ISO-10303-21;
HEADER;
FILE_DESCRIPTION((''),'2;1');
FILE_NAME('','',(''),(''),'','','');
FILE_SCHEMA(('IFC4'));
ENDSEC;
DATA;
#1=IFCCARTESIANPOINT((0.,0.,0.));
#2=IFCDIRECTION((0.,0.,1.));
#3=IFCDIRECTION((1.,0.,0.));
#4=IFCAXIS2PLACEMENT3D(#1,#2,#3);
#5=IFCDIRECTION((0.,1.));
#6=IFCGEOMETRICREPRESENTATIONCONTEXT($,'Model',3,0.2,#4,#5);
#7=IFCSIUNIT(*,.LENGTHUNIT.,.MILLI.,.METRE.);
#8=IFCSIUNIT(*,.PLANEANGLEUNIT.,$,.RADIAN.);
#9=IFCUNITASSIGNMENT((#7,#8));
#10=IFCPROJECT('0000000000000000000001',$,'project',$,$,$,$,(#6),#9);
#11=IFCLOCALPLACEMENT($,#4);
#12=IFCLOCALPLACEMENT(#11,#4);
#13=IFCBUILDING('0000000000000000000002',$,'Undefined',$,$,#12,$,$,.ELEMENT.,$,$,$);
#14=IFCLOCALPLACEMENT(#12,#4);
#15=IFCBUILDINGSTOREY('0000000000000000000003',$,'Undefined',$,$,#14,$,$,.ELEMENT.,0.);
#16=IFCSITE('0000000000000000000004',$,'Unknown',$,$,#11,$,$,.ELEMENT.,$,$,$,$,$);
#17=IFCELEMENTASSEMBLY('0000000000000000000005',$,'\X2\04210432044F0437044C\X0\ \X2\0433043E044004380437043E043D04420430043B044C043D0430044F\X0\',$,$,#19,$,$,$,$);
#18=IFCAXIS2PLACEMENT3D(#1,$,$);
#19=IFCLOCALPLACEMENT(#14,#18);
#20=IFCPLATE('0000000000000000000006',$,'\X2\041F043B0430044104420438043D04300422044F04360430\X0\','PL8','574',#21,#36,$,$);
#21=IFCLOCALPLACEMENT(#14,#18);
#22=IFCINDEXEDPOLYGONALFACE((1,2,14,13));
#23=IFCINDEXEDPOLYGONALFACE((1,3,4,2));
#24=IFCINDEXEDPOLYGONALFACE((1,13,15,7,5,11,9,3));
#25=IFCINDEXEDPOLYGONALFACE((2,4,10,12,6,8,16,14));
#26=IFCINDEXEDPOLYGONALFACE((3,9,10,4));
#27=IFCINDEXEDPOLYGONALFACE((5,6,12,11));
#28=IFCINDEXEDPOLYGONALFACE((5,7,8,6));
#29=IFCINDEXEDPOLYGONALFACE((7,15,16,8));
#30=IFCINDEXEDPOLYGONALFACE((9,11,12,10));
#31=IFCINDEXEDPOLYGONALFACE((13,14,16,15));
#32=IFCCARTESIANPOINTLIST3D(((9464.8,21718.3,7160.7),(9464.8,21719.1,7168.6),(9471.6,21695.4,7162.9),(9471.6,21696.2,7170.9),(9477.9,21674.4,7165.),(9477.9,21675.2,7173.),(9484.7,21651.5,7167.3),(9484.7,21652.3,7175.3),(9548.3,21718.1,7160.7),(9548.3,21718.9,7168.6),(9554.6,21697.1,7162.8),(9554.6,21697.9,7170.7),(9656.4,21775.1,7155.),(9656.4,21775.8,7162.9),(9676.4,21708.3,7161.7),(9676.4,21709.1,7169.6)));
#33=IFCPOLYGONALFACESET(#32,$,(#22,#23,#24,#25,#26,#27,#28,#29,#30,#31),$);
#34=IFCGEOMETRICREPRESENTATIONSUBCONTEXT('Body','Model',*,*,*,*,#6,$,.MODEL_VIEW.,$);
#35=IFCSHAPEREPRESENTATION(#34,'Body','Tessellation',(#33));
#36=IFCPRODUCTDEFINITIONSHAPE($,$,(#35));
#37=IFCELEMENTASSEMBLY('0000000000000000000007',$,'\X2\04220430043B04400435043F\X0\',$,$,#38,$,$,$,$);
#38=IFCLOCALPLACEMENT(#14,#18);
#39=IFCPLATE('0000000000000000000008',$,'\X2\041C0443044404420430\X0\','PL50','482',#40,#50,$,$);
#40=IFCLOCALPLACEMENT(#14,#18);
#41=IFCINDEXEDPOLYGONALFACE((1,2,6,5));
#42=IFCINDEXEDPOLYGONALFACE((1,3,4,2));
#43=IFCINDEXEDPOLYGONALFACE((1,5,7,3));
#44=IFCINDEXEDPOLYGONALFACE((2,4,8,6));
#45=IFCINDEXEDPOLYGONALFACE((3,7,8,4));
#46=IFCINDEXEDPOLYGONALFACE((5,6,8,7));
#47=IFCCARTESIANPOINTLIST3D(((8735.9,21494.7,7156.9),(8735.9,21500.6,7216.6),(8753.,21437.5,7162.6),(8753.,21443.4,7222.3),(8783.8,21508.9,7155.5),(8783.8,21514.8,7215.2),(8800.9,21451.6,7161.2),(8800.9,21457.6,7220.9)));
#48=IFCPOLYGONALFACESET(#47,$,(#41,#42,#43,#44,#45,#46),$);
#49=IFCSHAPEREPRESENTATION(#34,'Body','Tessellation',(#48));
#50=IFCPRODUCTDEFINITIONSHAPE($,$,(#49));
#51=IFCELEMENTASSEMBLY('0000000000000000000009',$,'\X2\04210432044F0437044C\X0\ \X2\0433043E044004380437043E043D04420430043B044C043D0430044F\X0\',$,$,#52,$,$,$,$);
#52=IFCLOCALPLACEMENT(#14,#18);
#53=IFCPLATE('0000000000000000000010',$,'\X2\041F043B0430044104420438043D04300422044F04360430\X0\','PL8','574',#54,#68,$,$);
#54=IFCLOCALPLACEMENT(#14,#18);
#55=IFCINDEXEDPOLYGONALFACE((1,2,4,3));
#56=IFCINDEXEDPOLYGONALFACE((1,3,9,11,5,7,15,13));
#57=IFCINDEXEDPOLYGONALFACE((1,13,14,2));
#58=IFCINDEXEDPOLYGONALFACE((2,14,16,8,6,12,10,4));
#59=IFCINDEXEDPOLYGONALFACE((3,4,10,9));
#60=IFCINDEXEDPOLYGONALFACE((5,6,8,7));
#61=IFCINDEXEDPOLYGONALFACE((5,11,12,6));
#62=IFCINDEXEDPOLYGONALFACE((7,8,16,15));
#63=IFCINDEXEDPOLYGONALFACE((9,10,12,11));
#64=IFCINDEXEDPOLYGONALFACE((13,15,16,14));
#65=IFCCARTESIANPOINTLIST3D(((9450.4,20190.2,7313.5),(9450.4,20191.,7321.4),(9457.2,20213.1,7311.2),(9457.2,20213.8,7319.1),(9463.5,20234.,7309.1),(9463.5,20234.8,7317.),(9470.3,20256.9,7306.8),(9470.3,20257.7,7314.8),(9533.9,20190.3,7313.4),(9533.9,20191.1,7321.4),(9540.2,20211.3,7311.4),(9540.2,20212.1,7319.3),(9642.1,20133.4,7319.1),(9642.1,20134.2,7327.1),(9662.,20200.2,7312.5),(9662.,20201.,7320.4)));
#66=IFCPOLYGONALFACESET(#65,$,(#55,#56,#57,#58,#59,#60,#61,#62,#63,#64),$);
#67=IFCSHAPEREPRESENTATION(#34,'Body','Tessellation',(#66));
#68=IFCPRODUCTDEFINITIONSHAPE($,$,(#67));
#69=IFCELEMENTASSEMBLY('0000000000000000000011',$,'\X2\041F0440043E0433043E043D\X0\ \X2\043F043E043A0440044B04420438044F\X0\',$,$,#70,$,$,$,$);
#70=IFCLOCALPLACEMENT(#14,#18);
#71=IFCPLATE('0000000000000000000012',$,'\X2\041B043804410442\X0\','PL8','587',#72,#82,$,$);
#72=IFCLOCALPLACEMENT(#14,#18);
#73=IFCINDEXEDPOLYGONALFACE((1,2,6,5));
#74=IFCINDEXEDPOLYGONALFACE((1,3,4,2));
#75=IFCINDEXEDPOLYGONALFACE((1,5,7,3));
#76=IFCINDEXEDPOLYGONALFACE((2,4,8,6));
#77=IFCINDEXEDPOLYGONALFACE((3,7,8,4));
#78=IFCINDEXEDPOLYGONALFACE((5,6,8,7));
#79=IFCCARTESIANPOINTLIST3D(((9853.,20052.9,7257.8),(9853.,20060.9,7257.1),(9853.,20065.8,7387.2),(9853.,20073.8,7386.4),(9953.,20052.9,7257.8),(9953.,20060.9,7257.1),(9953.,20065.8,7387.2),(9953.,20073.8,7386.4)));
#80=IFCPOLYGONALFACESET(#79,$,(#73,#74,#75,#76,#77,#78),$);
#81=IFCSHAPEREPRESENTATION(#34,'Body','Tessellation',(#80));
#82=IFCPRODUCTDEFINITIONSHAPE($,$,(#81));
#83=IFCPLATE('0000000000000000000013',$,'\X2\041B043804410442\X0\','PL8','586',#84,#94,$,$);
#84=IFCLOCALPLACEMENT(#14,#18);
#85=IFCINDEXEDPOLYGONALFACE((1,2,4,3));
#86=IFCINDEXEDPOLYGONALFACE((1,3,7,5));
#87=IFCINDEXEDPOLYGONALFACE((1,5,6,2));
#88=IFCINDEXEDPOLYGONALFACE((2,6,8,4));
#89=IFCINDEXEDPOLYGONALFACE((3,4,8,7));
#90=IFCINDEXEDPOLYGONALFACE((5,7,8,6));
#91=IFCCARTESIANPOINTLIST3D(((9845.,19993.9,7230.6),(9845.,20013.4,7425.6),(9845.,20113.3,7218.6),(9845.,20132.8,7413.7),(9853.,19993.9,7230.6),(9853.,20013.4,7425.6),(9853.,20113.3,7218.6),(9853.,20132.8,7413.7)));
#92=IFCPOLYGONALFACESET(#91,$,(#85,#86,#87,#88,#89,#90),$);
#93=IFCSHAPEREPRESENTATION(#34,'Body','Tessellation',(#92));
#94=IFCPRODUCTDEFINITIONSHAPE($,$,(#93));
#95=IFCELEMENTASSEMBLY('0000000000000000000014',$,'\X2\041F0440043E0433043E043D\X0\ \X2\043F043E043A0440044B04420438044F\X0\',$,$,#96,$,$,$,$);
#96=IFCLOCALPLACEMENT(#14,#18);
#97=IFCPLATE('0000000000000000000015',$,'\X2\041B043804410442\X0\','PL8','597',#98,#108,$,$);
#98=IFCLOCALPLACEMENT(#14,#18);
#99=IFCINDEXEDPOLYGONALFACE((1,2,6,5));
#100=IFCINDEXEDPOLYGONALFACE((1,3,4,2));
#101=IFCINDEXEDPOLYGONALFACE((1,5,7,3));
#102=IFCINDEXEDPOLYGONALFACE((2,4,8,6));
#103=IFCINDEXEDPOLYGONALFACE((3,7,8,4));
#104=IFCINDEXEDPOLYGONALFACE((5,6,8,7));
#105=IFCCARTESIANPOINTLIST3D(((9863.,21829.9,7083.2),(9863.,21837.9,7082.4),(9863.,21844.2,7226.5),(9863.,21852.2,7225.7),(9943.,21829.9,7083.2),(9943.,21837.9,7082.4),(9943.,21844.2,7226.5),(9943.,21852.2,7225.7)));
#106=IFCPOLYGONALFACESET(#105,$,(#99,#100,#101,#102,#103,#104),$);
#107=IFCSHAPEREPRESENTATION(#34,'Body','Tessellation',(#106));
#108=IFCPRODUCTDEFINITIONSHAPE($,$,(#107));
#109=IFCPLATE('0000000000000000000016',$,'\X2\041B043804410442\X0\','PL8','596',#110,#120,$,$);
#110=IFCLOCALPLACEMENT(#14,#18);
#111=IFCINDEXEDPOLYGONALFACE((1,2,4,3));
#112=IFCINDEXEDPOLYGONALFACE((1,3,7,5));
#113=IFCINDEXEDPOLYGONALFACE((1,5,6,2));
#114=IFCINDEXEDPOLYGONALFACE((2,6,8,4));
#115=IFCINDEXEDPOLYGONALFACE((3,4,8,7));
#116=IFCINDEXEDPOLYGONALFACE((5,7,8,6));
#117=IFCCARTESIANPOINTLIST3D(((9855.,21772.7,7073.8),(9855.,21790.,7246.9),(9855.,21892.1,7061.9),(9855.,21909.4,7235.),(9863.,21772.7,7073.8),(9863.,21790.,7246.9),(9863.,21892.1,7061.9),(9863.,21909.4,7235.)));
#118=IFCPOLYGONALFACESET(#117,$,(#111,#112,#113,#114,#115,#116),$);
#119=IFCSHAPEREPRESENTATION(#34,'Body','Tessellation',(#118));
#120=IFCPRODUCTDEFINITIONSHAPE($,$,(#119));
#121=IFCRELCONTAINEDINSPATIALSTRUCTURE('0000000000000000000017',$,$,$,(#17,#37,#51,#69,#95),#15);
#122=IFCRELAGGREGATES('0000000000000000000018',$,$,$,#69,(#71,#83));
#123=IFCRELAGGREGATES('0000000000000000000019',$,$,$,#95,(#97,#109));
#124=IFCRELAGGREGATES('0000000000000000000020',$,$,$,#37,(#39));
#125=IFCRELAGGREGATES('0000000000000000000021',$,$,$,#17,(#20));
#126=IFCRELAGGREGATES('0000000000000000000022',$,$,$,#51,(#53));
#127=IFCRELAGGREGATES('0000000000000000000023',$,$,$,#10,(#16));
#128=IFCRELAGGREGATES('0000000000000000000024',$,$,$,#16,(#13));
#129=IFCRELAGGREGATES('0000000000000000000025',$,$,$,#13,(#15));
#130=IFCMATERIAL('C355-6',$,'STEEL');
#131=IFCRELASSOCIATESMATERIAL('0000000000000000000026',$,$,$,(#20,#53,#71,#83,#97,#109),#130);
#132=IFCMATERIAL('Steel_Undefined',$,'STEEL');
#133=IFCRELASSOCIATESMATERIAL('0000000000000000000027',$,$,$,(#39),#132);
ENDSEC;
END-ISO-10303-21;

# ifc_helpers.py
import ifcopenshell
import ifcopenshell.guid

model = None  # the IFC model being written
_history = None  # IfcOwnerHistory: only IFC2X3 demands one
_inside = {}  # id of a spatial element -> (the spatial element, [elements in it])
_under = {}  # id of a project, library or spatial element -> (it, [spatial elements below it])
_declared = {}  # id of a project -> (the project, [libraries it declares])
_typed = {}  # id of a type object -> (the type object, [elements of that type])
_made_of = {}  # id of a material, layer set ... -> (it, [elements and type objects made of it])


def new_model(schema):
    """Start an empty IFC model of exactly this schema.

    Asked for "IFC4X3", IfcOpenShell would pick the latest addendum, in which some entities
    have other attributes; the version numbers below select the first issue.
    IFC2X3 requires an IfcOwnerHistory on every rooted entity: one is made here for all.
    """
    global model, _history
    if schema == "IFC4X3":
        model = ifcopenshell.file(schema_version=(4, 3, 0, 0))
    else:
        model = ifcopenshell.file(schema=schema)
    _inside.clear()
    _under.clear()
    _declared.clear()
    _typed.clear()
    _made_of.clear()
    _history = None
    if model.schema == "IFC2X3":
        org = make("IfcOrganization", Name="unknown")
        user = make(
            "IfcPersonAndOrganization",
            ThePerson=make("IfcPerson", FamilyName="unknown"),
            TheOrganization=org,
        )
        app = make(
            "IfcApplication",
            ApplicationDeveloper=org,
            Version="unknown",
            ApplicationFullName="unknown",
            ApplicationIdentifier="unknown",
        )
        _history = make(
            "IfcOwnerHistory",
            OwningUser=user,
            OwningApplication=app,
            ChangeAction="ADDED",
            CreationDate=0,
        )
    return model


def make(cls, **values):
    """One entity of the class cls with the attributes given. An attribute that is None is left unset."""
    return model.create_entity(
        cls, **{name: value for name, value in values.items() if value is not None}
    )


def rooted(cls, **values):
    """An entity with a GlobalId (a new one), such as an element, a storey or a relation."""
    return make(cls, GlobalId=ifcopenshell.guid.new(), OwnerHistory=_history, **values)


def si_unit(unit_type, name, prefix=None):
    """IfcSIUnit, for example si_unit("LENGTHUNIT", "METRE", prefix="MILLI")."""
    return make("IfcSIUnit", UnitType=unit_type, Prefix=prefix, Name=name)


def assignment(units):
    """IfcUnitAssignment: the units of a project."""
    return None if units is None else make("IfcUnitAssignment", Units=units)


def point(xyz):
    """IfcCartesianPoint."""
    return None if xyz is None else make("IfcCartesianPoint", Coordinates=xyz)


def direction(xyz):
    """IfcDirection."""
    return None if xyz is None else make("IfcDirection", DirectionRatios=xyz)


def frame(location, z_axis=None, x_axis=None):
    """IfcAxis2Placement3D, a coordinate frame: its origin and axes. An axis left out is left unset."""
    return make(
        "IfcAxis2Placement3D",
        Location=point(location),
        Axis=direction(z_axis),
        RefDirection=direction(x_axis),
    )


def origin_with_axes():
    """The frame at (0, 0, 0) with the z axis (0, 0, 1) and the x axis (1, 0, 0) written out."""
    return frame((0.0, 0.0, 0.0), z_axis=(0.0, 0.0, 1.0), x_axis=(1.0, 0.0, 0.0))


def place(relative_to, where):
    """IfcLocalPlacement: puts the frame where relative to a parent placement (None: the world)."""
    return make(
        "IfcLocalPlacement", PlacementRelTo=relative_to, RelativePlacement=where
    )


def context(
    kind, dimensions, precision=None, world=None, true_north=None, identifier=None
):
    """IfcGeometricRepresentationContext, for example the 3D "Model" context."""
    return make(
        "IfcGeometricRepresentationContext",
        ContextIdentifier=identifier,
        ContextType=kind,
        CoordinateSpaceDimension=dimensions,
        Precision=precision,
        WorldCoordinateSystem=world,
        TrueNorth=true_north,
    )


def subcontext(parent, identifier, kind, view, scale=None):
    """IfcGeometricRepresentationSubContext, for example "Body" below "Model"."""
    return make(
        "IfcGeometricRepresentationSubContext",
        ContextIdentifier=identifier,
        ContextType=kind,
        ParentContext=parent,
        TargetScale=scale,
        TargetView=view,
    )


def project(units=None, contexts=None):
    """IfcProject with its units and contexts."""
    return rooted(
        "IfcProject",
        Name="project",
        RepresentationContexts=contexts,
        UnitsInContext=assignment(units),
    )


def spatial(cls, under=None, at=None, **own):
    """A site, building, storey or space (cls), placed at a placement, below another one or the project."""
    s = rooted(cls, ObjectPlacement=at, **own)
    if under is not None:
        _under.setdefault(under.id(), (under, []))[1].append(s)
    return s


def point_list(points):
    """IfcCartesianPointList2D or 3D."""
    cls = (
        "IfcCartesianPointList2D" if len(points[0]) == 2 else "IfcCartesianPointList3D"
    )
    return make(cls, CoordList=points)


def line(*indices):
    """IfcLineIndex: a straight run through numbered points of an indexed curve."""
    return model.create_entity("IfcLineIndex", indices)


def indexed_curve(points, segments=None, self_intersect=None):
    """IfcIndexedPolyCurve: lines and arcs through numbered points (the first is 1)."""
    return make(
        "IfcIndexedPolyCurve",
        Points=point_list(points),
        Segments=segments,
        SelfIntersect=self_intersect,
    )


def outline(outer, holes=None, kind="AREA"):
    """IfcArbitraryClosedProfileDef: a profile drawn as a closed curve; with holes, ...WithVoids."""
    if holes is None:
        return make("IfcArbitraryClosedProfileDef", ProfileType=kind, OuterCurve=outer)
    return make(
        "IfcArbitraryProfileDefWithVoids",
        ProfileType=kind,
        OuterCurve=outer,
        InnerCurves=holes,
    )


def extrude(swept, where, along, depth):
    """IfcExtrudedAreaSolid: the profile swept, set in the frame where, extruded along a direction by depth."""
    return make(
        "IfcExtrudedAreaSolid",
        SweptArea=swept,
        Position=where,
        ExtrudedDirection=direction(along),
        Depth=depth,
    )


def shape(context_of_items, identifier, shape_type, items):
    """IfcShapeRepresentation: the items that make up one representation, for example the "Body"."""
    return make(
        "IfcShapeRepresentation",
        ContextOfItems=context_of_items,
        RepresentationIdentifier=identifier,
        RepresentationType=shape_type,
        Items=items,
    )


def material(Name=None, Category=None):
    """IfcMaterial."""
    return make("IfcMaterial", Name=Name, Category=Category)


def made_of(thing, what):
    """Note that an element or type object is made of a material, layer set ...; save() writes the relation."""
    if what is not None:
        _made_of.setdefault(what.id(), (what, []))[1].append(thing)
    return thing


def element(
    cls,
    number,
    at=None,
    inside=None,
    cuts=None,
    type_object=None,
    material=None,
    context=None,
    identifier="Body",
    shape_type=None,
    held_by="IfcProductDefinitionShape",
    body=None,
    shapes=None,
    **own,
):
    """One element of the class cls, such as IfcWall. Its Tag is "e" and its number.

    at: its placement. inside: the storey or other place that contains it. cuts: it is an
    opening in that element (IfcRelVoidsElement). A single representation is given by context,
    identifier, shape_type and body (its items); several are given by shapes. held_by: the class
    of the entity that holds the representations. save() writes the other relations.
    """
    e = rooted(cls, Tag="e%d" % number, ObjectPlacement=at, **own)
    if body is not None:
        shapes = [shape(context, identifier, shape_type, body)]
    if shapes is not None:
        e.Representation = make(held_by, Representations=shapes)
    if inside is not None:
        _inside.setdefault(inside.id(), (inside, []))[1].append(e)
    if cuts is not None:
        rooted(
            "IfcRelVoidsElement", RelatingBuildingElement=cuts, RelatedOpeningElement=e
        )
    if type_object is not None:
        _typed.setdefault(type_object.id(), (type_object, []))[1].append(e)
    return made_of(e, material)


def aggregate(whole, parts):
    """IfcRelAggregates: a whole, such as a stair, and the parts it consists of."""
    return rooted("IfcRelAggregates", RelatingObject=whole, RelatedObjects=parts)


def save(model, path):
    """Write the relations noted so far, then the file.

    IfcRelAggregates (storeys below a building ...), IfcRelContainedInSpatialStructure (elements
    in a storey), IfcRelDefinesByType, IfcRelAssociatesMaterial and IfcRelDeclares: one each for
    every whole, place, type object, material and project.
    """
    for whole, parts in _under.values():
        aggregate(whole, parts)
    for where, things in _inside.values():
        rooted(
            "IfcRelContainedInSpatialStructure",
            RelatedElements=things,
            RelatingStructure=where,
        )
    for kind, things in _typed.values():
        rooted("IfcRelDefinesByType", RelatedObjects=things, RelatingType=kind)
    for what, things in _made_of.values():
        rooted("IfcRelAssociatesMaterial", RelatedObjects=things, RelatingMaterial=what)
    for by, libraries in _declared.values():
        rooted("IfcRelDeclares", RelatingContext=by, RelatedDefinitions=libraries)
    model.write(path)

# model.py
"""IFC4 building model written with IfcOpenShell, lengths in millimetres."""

from ifc_helpers import new_model, si_unit, direction, frame, origin_with_axes, place, context, subcontext, project, spatial, line, indexed_curve, outline, extrude, material, element, aggregate, save


model = new_model("IFC4")

# Units and contexts
model_context = context("Model", 3, precision=0.2, world=origin_with_axes(), true_north=direction((0.0, 1.0)))
body_context = subcontext(model_context, "Body", "Model", "MODEL_VIEW")
ifc_project = project(units=[si_unit("LENGTHUNIT", "METRE", prefix="MILLI"), si_unit("PLANEANGLEUNIT", "RADIAN")], contexts=[model_context])

# Site, building, storey
site_placement = place(None, origin_with_axes())
site = spatial("IfcSite", under=ifc_project, at=site_placement, Name="Unknown", CompositionType="ELEMENT")
building_placement = place(site_placement, origin_with_axes())
building = spatial("IfcBuilding", under=site, at=building_placement, Name="Undefined", CompositionType="ELEMENT")
storey_placement = place(building_placement, origin_with_axes())
storey = spatial("IfcBuildingStorey", under=building, at=storey_placement, Name="Undefined", CompositionType="ELEMENT", Elevation=0.0)

# Shared definitions
ifc_material_1 = material(Name="Steel_Undefined", Category="STEEL")

# Shared definitions
ifc_material_2 = material(Name="C355-6", Category="STEEL")

# Element assembly, plate, voiding feature
assembly_1_placement = place(storey_placement, frame((8658.2, 21443.5, 7192.2), z_axis=(0.285231, -0.953702, 0.09537), x_axis=(0.958459, 0.283816, -0.028382)))
assembly_1 = element("IfcElementAssembly", 1, at=assembly_1_placement, inside=storey, Name="Связь горизонтальная")
plate_1_placement = place(assembly_1_placement, frame((1052.0, 0.0, 35.0), z_axis=(0.0, 1.0, 0.0), x_axis=(0.0, 0.0, -1.0)))
plate_1 = element("IfcPlate", 2, at=plate_1_placement, material=ifc_material_2, Name="ПластинаТяжа", Description="PL8", ObjectType="574", context=body_context, shape_type="SolidModel", body=[
    extrude(outline(indexed_curve([(0.0, 0.0), (70.0, 0.0), (70.0, 200.0), (0.0, 200.0)], segments=[line(1, 2, 3, 4, 1)])), frame((0.0, 0.0, 4.0), z_axis=(0.0, 0.0, 1.0), x_axis=(1.0, 0.0, 0.0)), (0.0, 0.0, -1.0), 8.0),
])
voiding_feature_1_placement = place(plate_1_placement, frame((24.0, 120.0, 0.0), z_axis=(0.0, 0.0, 1.0), x_axis=(1.0, 0.0, 0.0)))
element("IfcVoidingFeature", 3, at=voiding_feature_1_placement, cuts=plate_1, Name="PLATE", ObjectType="(?)", PredefinedType="HOLE", context=body_context, shape_type="SolidModel", body=[
    extrude(outline(indexed_curve([(0.0, 0.0), (22.0, 0.0), (22.0, 85.0), (0.0, 85.0)], segments=[line(1, 2, 3, 4, 1)])), frame((0.0, 0.0, 6.5), z_axis=(0.0, 0.0, 1.0), x_axis=(1.0, 0.0, 0.0)), (0.0, 0.0, -1.0), 13.0),
])

# Element assembly, plate
assembly_2_placement = place(storey_placement, frame((8776.9, 21450.5, 7221.6), z_axis=(-0.958459, -0.283816, 0.028382), x_axis=(-0.285231, 0.953702, -0.09537)))
assembly_2 = element("IfcElementAssembly", 4, at=assembly_2_placement, inside=storey, Name="Талреп")
plate_2_placement = place(assembly_2_placement, origin_with_axes())
plate_2 = element("IfcPlate", 5, at=plate_2_placement, material=ifc_material_1, Name="Муфта", Description="PL50", ObjectType="482", context=body_context, shape_type="SolidModel", body=[
    extrude(outline(indexed_curve([(0.0, 0.0), (60.0, 0.0), (60.0, 60.0), (0.0, 60.0)], segments=[line(1, 2, 3, 4, 1)])), frame((0.0, 0.0, 25.0), z_axis=(0.0, 0.0, 1.0), x_axis=(1.0, 0.0, 0.0)), (0.0, 0.0, -1.0), 50.0),
])

# Element assembly, plate, voiding feature
assembly_3_placement = place(storey_placement, frame((8658.2, 20461.5, 7290.4), z_axis=(-0.285231, -0.953702, 0.09537), x_axis=(0.958459, -0.283816, 0.028382)))
assembly_3 = element("IfcElementAssembly", 6, at=assembly_3_placement, inside=storey, Name="Связь горизонтальная")
plate_3_placement = place(assembly_3_placement, frame((1037.0, 0.0, 35.0), z_axis=(0.0, 1.0, 0.0), x_axis=(0.0, 0.0, -1.0)))
plate_3 = element("IfcPlate", 7, at=plate_3_placement, material=ifc_material_2, Name="ПластинаТяжа", Description="PL8", ObjectType="574", context=body_context, shape_type="SolidModel", body=[
    extrude(outline(indexed_curve([(0.0, 0.0), (70.0, 0.0), (70.0, 200.0), (0.0, 200.0)], segments=[line(1, 2, 3, 4, 1)])), frame((0.0, 0.0, 4.0), z_axis=(0.0, 0.0, 1.0), x_axis=(1.0, 0.0, 0.0)), (0.0, 0.0, -1.0), 8.0),
])
voiding_feature_2_placement = place(plate_3_placement, frame((24.0, 120.0, 0.0), z_axis=(0.0, 0.0, 1.0), x_axis=(1.0, 0.0, 0.0)))
element("IfcVoidingFeature", 8, at=voiding_feature_2_placement, cuts=plate_3, Name="PLATE", ObjectType="(?)", PredefinedType="HOLE", context=body_context, shape_type="SolidModel", body=[
    extrude(outline(indexed_curve([(0.0, 0.0), (22.0, 0.0), (22.0, 85.0), (0.0, 85.0)], segments=[line(1, 2, 3, 4, 1)])), frame((0.0, 0.0, 6.5), z_axis=(0.0, 0.0, 1.0), x_axis=(1.0, 0.0, 0.0)), (0.0, 0.0, -1.0), 13.0),
])

# Element assemblies, plates
assembly_4_placement = place(storey_placement, frame((10000.0, 20063.3, 7322.1), z_axis=(0.0, -0.995037, 0.099504), x_axis=(-1.0, 0.0, 0.0)))
assembly_4 = element("IfcElementAssembly", 9, at=assembly_4_placement, inside=storey, Name="Прогон покрытия")
plate_4_placement = place(assembly_4_placement, frame((47.0, -65.0, 0.0), z_axis=(0.0, 0.0, 1.0), x_axis=(1.0, 0.0, 0.0)))
plate_4 = element("IfcPlate", 10, at=plate_4_placement, material=ifc_material_2, Name="Лист", Description="PL8", ObjectType="587", context=body_context, shape_type="SolidModel", body=[
    extrude(outline(indexed_curve([(0.0, 0.0), (100.0, 0.0), (100.0, 130.0), (0.0, 130.0)], segments=[line(1, 2, 3, 4, 1)])), frame((0.0, 0.0, 4.0), z_axis=(0.0, 0.0, 1.0), x_axis=(1.0, 0.0, 0.0)), (0.0, 0.0, -1.0), 8.0),
])
plate_5_placement = place(assembly_4_placement, frame((151.0, -98.0, -60.0), z_axis=(-1.0, 0.0, 0.0), x_axis=(0.0, 0.0, 1.0)))
plate_5 = element("IfcPlate", 11, at=plate_5_placement, material=ifc_material_2, Name="Лист", Description="PL8", ObjectType="586", context=body_context, shape_type="SolidModel", body=[
    extrude(outline(indexed_curve([(0.0, 0.0), (120.0, 0.0), (120.0, 196.0), (0.0, 196.0)], segments=[line(1, 2, 3, 4, 1)])), frame((0.0, 0.0, 4.0), z_axis=(0.0, 0.0, 1.0), x_axis=(1.0, 0.0, 0.0)), (0.0, 0.0, -1.0), 8.0),
])
aggregate(assembly_4, [plate_4, plate_5])
assembly_5_placement = place(storey_placement, frame((10000.0, 21841.0, 7154.4), z_axis=(0.0, -0.995037, 0.099504), x_axis=(-1.0, 0.0, 0.0)))
assembly_5 = element("IfcElementAssembly", 12, at=assembly_5_placement, inside=storey, Name="Прогон покрытия")
plate_6_placement = place(assembly_5_placement, frame((57.0, -72.0, 0.0), z_axis=(0.0, 0.0, 1.0), x_axis=(1.0, 0.0, 0.0)))
plate_6 = element("IfcPlate", 13, at=plate_6_placement, material=ifc_material_2, Name="Лист", Description="PL8", ObjectType="597", context=body_context, shape_type="SolidModel", body=[
    extrude(outline(indexed_curve([(0.0, 0.0), (80.0, 0.0), (80.0, 144.0), (0.0, 144.0)], segments=[line(1, 2, 3, 4, 1)])), frame((0.0, 0.0, 4.0), z_axis=(0.0, 0.0, 1.0), x_axis=(1.0, 0.0, 0.0)), (0.0, 0.0, -1.0), 8.0),
])
plate_7_placement = place(assembly_5_placement, frame((141.0, -87.0, -60.0), z_axis=(-1.0, 0.0, 0.0), x_axis=(0.0, 0.0, 1.0)))
plate_7 = element("IfcPlate", 14, at=plate_7_placement, material=ifc_material_2, Name="Лист", Description="PL8", ObjectType="596", context=body_context, shape_type="SolidModel", body=[
    extrude(outline(indexed_curve([(0.0, 0.0), (120.0, 0.0), (120.0, 174.0), (0.0, 174.0)], segments=[line(1, 2, 3, 4, 1)])), frame((0.0, 0.0, 4.0), z_axis=(0.0, 0.0, 1.0), x_axis=(1.0, 0.0, 0.0)), (0.0, 0.0, -1.0), 8.0),
])
aggregate(assembly_5, [plate_6, plate_7])

aggregate(assembly_2, [plate_2])

aggregate(assembly_1, [plate_1])
aggregate(assembly_3, [plate_3])

save(model, "model.ifc")
